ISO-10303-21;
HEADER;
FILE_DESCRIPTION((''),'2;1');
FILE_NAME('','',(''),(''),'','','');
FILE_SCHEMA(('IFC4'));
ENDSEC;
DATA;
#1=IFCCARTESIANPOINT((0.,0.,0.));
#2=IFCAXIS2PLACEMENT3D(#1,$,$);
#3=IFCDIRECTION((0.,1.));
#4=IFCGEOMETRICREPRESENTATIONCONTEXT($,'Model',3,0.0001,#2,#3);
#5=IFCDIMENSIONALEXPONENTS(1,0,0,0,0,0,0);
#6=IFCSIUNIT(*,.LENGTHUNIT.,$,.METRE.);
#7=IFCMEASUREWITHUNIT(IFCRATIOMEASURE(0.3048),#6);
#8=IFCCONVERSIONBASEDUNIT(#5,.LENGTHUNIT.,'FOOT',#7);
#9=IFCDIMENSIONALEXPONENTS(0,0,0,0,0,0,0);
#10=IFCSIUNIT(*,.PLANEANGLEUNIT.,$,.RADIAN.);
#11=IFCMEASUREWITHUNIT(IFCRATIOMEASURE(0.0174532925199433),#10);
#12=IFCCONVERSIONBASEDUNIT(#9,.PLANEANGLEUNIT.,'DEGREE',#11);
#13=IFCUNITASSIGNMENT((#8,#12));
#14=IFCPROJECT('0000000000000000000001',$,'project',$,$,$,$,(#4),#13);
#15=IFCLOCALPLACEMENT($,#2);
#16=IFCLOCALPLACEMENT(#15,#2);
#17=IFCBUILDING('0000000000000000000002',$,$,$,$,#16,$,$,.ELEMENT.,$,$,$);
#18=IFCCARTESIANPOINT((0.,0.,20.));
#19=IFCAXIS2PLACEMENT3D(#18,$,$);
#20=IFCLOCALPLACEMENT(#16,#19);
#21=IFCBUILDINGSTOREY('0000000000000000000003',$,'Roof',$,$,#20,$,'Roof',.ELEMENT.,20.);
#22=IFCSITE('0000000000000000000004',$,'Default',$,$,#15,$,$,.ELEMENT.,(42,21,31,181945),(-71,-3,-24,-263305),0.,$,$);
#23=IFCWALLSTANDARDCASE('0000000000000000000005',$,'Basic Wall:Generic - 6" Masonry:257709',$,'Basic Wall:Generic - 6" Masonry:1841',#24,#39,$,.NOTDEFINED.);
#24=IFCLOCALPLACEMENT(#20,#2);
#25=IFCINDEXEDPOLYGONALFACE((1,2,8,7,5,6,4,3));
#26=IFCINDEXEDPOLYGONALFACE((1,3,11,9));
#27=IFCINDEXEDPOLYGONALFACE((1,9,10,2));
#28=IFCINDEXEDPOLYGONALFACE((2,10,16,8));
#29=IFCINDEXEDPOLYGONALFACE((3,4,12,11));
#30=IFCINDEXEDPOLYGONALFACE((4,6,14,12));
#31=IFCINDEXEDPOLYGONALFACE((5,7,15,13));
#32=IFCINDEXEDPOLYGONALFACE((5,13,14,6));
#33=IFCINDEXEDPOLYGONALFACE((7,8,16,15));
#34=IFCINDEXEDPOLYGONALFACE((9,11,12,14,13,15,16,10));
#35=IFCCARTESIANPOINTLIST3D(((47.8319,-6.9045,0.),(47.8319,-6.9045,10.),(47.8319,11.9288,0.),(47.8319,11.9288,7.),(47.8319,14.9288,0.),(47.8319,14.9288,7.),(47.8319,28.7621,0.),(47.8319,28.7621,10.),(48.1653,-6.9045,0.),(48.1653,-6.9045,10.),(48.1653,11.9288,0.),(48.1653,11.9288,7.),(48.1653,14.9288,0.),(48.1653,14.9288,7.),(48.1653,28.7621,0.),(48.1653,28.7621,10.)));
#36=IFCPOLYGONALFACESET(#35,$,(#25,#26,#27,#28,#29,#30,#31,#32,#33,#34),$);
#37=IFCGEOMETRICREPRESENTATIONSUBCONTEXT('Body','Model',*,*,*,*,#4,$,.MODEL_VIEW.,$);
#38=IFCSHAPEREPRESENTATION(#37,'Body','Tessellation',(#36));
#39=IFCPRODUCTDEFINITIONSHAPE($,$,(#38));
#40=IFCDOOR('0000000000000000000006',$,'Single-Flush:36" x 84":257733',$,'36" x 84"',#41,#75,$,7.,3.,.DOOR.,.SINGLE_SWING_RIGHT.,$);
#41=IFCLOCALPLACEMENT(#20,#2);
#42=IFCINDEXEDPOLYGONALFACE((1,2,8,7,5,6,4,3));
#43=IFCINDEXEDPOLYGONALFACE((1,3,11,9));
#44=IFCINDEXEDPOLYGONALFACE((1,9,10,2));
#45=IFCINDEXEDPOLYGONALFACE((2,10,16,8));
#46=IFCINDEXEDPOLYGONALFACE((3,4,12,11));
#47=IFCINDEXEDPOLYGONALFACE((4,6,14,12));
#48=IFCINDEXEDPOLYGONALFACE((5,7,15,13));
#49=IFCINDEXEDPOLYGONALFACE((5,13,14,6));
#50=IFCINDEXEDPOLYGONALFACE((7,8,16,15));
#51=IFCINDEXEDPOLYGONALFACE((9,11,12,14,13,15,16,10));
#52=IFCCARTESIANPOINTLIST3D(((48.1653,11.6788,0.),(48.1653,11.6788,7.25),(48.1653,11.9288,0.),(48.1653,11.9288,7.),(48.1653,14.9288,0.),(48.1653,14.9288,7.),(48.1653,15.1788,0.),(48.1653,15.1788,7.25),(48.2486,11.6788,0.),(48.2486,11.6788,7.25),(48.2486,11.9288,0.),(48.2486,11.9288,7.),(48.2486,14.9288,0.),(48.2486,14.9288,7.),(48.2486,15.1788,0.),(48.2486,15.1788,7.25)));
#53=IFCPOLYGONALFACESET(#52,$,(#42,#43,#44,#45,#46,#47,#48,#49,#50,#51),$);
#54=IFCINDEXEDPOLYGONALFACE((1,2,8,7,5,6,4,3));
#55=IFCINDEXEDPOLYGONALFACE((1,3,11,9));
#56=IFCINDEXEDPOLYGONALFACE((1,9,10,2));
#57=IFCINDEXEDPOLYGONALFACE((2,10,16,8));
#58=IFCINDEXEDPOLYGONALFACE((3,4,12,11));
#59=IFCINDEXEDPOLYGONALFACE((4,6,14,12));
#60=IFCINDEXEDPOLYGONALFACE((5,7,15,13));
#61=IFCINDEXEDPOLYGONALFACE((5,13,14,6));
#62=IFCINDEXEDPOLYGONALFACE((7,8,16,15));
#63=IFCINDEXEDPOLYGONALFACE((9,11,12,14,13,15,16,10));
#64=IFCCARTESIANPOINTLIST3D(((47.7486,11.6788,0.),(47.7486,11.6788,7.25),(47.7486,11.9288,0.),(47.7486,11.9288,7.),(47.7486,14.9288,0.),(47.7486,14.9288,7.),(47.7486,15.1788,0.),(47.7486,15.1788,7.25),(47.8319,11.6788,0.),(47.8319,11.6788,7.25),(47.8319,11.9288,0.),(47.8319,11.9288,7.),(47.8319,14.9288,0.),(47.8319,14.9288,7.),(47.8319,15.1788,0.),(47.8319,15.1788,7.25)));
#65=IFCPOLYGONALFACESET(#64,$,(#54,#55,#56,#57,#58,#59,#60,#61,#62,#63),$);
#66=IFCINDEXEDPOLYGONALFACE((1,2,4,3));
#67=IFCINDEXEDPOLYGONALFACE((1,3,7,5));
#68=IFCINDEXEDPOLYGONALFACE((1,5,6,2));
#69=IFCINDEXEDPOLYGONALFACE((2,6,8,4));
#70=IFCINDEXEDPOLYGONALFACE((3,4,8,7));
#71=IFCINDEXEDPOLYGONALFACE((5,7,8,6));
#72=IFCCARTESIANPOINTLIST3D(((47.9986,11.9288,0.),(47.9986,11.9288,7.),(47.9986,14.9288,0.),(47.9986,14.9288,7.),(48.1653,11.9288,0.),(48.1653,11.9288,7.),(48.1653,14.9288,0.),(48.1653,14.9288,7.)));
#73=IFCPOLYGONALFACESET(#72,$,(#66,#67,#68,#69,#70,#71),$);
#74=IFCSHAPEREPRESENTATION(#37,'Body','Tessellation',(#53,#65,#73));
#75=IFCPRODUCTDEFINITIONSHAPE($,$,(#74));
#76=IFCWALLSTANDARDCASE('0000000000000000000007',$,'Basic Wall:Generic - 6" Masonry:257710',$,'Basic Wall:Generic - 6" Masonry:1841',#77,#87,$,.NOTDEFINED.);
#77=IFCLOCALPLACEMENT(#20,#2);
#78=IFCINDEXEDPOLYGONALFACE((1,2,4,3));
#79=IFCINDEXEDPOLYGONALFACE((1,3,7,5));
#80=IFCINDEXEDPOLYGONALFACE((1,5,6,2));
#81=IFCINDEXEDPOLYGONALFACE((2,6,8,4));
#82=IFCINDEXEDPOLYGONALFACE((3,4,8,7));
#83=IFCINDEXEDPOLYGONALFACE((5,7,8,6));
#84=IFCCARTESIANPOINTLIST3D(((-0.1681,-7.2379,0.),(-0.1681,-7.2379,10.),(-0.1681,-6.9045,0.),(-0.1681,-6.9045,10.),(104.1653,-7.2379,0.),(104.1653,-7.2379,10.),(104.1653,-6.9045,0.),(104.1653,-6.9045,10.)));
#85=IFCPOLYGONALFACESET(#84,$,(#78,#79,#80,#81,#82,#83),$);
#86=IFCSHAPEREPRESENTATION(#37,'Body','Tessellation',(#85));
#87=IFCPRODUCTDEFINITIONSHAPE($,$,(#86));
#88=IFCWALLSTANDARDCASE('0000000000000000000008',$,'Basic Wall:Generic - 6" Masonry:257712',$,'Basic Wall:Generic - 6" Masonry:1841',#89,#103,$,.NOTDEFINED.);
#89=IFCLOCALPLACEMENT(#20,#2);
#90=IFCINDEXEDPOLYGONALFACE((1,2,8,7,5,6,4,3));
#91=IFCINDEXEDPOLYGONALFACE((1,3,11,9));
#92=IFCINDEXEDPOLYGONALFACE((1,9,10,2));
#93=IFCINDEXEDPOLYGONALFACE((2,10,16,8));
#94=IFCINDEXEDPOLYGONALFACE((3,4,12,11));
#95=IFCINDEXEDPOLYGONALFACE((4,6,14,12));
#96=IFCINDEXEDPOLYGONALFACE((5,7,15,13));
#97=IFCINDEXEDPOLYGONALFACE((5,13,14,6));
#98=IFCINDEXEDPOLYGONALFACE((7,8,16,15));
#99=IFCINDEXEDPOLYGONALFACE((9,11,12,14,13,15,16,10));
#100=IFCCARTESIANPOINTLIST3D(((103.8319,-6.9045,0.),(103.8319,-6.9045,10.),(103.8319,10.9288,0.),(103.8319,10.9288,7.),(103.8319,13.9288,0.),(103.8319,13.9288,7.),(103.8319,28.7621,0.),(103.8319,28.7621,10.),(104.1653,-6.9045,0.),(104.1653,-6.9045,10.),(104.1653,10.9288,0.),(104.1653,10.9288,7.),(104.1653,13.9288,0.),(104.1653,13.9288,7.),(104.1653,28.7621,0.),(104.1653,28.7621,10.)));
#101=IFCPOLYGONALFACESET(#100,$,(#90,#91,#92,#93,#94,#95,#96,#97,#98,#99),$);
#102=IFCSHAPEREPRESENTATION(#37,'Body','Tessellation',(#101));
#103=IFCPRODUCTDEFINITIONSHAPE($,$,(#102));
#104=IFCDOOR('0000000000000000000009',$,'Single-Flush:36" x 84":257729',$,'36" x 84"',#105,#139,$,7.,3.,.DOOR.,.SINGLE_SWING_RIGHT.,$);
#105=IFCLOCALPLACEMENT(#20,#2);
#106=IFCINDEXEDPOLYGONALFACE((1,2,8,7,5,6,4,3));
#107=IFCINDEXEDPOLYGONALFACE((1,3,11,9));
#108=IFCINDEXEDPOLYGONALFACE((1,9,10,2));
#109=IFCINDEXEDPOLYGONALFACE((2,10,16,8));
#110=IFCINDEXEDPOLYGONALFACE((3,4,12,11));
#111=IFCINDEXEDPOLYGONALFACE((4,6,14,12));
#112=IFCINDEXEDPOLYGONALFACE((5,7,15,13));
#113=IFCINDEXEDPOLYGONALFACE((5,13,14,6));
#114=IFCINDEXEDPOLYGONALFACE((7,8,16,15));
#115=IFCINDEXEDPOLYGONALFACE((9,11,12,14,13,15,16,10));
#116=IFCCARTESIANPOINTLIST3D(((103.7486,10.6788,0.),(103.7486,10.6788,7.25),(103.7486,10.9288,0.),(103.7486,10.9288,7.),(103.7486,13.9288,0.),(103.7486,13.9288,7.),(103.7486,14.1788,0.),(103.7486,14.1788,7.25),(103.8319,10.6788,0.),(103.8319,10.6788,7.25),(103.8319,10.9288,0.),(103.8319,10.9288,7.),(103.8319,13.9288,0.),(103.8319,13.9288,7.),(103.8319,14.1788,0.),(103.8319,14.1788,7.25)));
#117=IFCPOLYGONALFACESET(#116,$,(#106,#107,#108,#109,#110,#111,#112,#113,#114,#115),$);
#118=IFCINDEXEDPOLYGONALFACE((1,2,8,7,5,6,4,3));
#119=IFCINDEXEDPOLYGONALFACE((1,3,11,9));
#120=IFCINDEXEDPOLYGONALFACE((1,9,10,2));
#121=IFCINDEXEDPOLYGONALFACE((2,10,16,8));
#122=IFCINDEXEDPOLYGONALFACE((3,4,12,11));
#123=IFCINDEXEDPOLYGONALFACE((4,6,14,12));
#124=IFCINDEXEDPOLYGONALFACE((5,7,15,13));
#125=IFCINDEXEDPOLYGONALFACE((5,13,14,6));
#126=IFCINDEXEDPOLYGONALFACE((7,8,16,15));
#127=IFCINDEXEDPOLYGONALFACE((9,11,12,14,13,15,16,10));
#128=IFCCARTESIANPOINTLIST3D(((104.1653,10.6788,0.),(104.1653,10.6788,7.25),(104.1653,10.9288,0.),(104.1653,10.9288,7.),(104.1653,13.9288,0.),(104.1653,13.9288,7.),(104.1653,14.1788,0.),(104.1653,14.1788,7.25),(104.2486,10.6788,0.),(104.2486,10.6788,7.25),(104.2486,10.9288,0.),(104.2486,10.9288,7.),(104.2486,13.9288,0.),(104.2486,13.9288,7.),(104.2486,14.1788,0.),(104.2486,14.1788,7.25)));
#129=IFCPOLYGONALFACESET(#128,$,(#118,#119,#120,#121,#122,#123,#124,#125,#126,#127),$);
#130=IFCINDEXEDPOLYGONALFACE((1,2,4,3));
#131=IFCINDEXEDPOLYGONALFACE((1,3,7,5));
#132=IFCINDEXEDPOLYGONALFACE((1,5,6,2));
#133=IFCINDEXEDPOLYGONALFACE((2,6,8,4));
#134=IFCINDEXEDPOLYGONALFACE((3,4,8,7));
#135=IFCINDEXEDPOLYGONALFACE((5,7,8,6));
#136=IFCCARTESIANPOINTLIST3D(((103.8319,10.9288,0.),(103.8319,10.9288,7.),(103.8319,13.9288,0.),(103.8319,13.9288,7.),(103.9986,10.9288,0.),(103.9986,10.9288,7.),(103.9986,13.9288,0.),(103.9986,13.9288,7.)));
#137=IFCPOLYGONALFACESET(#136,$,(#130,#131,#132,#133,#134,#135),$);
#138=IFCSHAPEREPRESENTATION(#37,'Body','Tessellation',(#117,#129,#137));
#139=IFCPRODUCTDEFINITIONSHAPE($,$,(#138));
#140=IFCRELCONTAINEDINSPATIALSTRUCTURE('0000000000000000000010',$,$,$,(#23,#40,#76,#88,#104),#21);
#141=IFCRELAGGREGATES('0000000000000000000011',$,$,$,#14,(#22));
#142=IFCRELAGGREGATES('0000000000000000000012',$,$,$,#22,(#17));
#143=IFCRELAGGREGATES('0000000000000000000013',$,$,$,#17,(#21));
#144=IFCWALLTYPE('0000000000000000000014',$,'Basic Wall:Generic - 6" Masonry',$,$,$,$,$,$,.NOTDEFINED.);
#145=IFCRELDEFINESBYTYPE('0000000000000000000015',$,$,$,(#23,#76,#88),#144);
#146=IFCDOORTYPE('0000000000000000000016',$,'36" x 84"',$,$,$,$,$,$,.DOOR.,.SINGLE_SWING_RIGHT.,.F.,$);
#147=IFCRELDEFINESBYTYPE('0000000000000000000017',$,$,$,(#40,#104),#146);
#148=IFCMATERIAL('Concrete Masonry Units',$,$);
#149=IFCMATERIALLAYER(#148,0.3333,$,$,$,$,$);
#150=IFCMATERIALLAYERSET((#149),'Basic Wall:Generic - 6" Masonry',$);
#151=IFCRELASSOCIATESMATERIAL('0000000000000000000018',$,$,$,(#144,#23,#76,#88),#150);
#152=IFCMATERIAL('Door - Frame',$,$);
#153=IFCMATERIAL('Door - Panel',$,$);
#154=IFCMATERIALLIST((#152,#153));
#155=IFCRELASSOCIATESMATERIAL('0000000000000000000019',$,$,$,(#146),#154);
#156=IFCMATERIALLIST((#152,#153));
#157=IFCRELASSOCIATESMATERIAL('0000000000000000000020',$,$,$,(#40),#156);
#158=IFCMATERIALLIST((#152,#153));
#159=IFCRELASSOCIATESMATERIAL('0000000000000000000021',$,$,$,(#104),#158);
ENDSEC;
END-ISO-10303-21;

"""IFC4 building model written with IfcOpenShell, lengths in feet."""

from ifc_helpers import new_model, entity, si_unit, converted_unit, direction, frame, frame_2d, origin, place, context, subcontext, project, spatial, polyline, rectangle, outline, extrude, source, transform, mapped, material, material_list, layer, layer_set, layer_usage, type_object, type_shapes, element, fill, save


model = new_model("IFC4")

# Units and contexts
model_context = context("Model", 3, precision=0.0001, world=origin(), true_north=direction((0.0, 1.0)))
body_context = subcontext(model_context, "Body", "Model", "MODEL_VIEW")
ifc_project = project(units=[converted_unit("LENGTHUNIT", "FOOT", entity("IfcRatioMeasure", 0.3048), si_unit("LENGTHUNIT", "METRE"), dimensions=[1, 0, 0, 0, 0, 0, 0]), converted_unit("PLANEANGLEUNIT", "DEGREE", entity("IfcRatioMeasure", 0.0174532925199433), si_unit("PLANEANGLEUNIT", "RADIAN"), dimensions=[0, 0, 0, 0, 0, 0, 0])], contexts=[model_context])

# Site, building, storey
site_placement = place(None, origin())
site = spatial("IfcSite", under=ifc_project, at=site_placement, Name="Default", CompositionType="ELEMENT", RefLatitude=(42, 21, 31, 181945), RefLongitude=(-71, -3, -24, -263305), RefElevation=0.0)
building_placement = place(site_placement, origin())
building = spatial("IfcBuilding", under=site, at=building_placement, CompositionType="ELEMENT")
storey_placement = place(building_placement, frame((0.0, 0.0, 20.0)))
storey = spatial("IfcBuildingStorey", under=building, at=storey_placement, Name="Roof", LongName="Roof", CompositionType="ELEMENT", Elevation=20.0)

# Wall, opening, door
ifc_material_1 = material(Name="Concrete Masonry Units")
ifc_layer = layer(ifc_material_1, 0.3333)
ifc_layer_set = layer_set([ifc_layer], Name="Basic Wall:Generic - 6\" Masonry")
ifc_layer_usage_1 = layer_usage(ifc_layer_set, "AXIS2", "NEGATIVE", 0.1667)
wall_type = type_object("IfcWallType", Name="Basic Wall:Generic - 6\" Masonry", PredefinedType="NOTDEFINED", material=ifc_layer_set)
wall_1_placement = place(storey_placement, frame((47.9986, 28.7621, 0.0), z_axis=(0.0, 0.0, 1.0), x_axis=(0.0, -1.0, 0.0)))
wall_1 = element("IfcWallStandardCase", 1, at=wall_1_placement, inside=storey, type_object=wall_type, material=ifc_layer_usage_1, Name="Basic Wall:Generic - 6\" Masonry:257709", ObjectType="Basic Wall:Generic - 6\" Masonry:1841", PredefinedType="NOTDEFINED", context=body_context, shape_type="SweptSolid", body=[
    extrude(rectangle(XDim=35.6667, YDim=0.3333, at=frame_2d((17.8333, 0.0), x_axis=(-1.0, 0.0))), origin(), (0.0, 0.0, 1.0), 10.0),
])
opening_1_placement = place(wall_1_placement, frame((13.8333, -0.1667, 0.0)))
opening_1 = element("IfcOpeningElement", 2, at=opening_1_placement, cuts=wall_1, ObjectType="Opening", PredefinedType="OPENING", context=body_context, shape_type="SweptSolid", body=[
    extrude(rectangle(XDim=3.0, YDim=7.0, at=frame_2d((3.5, 1.5), x_axis=(0.0, 1.0))), frame((0.0, 0.0, 0.0), z_axis=(0.0, 1.0, 0.0), x_axis=(0.0, 0.0, 1.0)), (0.0, 0.0, 1.0), 0.3333),
])
ifc_material_2 = material(Name="Door - Frame")
ifc_material_3 = material(Name="Door - Panel")
ifc_material_list_1 = material_list([ifc_material_2, ifc_material_3])
ifc_material_list_2 = material_list([ifc_material_2, ifc_material_3])
door_type = type_object("IfcDoorType", Name="36\" x 84\"", OperationType="SINGLE_SWING_RIGHT", ParameterTakesPrecedence=False, PredefinedType="DOOR", material=ifc_material_list_2)
shared_shape_1 = source(origin(), body_context, "Body", "SweptSolid", [
    extrude(outline(polyline([(-1.75, -3.6875), (1.75, -3.6875), (1.75, 3.5625), (1.5, 3.5625), (1.5, -3.4375), (-1.5, -3.4375), (-1.5, 3.5625), (-1.75, 3.5625), (-1.75, -3.6875)])), frame((1.5, 0.3333, 3.5625), z_axis=(0.0, 1.0, 0.0), x_axis=(1.0, 0.0, 0.0)), (0.0, 0.0, 1.0), 0.0833),
    extrude(outline(polyline([(-3.6875, -1.75), (3.5625, -1.75), (3.5625, -1.5), (-3.4375, -1.5), (-3.4375, 1.5), (3.5625, 1.5), (3.5625, 1.75), (-3.6875, 1.75), (-3.6875, -1.75)])), frame((1.5, -0.0833, 3.5625), z_axis=(0.0, 1.0, 0.0), x_axis=(0.0, 0.0, -1.0)), (0.0, 0.0, 1.0), 0.0833),
    extrude(rectangle(XDim=0.1667, YDim=3.0, at=frame_2d((0.0, 0.0), x_axis=(1.0, 0.0))), frame((1.5, 0.25, 0.0), z_axis=(0.0, 0.0, 1.0), x_axis=(0.0, 1.0, 0.0)), (0.0, 0.0, 1.0), 7.0),
])
type_shapes(door_type, [shared_shape_1])
door_1_placement = place(opening_1_placement, origin())
door_1 = element("IfcDoor", 3, at=door_1_placement, inside=storey, type_object=door_type, material=ifc_material_list_1, Name="Single-Flush:36\" x 84\":257733", ObjectType="36\" x 84\"", OperationType="SINGLE_SWING_RIGHT", OverallHeight=7.0, OverallWidth=3.0, PredefinedType="DOOR", context=body_context, shape_type="MappedRepresentation", body=[
    mapped(shared_shape_1, transform((0.0, 0.0, 0.0), scale=1.0)),
])
fill(opening_1, door_1)

# Wall
ifc_layer_usage_2 = layer_usage(ifc_layer_set, "AXIS2", "NEGATIVE", 0.1667)
wall_2_placement = place(storey_placement, frame((104.1653, -7.0712, 0.0), z_axis=(0.0, 0.0, 1.0), x_axis=(-1.0, 0.0, 0.0)))
element("IfcWallStandardCase", 4, at=wall_2_placement, inside=storey, type_object=wall_type, material=ifc_layer_usage_2, Name="Basic Wall:Generic - 6\" Masonry:257710", ObjectType="Basic Wall:Generic - 6\" Masonry:1841", PredefinedType="NOTDEFINED", context=body_context, shape_type="SweptSolid", body=[
    extrude(rectangle(XDim=104.3333, YDim=0.3333, at=frame_2d((52.1667, 0.0), x_axis=(-1.0, 0.0))), origin(), (0.0, 0.0, 1.0), 10.0),
])

# Wall, opening, door
ifc_layer_usage_3 = layer_usage(ifc_layer_set, "AXIS2", "NEGATIVE", 0.1667)
wall_3_placement = place(storey_placement, frame((103.9986, -6.9045, 0.0), z_axis=(0.0, 0.0, 1.0), x_axis=(0.0, 1.0, 0.0)))
wall_3 = element("IfcWallStandardCase", 5, at=wall_3_placement, inside=storey, type_object=wall_type, material=ifc_layer_usage_3, Name="Basic Wall:Generic - 6\" Masonry:257712", ObjectType="Basic Wall:Generic - 6\" Masonry:1841", PredefinedType="NOTDEFINED", context=body_context, shape_type="SweptSolid", body=[
    extrude(rectangle(XDim=35.6667, YDim=0.3333, at=frame_2d((17.8333, 0.0), x_axis=(-1.0, 0.0))), origin(), (0.0, 0.0, 1.0), 10.0),
])
opening_2_placement = place(wall_3_placement, frame((17.8333, -0.1667, 0.0)))
opening_2 = element("IfcOpeningElement", 6, at=opening_2_placement, cuts=wall_3, ObjectType="Opening", PredefinedType="OPENING", context=body_context, shape_type="SweptSolid", body=[
    extrude(rectangle(XDim=3.0, YDim=7.0, at=frame_2d((3.5, 1.5), x_axis=(0.0, 1.0))), frame((0.0, 0.0, 0.0), z_axis=(0.0, 1.0, 0.0), x_axis=(0.0, 0.0, 1.0)), (0.0, 0.0, 1.0), 0.3333),
])
ifc_material_list_3 = material_list([ifc_material_2, ifc_material_3])
door_2_placement = place(opening_2_placement, origin())
door_2 = element("IfcDoor", 7, at=door_2_placement, inside=storey, type_object=door_type, material=ifc_material_list_3, Name="Single-Flush:36\" x 84\":257729", ObjectType="36\" x 84\"", OperationType="SINGLE_SWING_RIGHT", OverallHeight=7.0, OverallWidth=3.0, PredefinedType="DOOR", context=body_context, shape_type="MappedRepresentation", body=[
    mapped(shared_shape_1, transform((0.0, 0.0, 0.0), scale=1.0)),
])
fill(opening_2, door_2)

save(model, "model.ifc")
